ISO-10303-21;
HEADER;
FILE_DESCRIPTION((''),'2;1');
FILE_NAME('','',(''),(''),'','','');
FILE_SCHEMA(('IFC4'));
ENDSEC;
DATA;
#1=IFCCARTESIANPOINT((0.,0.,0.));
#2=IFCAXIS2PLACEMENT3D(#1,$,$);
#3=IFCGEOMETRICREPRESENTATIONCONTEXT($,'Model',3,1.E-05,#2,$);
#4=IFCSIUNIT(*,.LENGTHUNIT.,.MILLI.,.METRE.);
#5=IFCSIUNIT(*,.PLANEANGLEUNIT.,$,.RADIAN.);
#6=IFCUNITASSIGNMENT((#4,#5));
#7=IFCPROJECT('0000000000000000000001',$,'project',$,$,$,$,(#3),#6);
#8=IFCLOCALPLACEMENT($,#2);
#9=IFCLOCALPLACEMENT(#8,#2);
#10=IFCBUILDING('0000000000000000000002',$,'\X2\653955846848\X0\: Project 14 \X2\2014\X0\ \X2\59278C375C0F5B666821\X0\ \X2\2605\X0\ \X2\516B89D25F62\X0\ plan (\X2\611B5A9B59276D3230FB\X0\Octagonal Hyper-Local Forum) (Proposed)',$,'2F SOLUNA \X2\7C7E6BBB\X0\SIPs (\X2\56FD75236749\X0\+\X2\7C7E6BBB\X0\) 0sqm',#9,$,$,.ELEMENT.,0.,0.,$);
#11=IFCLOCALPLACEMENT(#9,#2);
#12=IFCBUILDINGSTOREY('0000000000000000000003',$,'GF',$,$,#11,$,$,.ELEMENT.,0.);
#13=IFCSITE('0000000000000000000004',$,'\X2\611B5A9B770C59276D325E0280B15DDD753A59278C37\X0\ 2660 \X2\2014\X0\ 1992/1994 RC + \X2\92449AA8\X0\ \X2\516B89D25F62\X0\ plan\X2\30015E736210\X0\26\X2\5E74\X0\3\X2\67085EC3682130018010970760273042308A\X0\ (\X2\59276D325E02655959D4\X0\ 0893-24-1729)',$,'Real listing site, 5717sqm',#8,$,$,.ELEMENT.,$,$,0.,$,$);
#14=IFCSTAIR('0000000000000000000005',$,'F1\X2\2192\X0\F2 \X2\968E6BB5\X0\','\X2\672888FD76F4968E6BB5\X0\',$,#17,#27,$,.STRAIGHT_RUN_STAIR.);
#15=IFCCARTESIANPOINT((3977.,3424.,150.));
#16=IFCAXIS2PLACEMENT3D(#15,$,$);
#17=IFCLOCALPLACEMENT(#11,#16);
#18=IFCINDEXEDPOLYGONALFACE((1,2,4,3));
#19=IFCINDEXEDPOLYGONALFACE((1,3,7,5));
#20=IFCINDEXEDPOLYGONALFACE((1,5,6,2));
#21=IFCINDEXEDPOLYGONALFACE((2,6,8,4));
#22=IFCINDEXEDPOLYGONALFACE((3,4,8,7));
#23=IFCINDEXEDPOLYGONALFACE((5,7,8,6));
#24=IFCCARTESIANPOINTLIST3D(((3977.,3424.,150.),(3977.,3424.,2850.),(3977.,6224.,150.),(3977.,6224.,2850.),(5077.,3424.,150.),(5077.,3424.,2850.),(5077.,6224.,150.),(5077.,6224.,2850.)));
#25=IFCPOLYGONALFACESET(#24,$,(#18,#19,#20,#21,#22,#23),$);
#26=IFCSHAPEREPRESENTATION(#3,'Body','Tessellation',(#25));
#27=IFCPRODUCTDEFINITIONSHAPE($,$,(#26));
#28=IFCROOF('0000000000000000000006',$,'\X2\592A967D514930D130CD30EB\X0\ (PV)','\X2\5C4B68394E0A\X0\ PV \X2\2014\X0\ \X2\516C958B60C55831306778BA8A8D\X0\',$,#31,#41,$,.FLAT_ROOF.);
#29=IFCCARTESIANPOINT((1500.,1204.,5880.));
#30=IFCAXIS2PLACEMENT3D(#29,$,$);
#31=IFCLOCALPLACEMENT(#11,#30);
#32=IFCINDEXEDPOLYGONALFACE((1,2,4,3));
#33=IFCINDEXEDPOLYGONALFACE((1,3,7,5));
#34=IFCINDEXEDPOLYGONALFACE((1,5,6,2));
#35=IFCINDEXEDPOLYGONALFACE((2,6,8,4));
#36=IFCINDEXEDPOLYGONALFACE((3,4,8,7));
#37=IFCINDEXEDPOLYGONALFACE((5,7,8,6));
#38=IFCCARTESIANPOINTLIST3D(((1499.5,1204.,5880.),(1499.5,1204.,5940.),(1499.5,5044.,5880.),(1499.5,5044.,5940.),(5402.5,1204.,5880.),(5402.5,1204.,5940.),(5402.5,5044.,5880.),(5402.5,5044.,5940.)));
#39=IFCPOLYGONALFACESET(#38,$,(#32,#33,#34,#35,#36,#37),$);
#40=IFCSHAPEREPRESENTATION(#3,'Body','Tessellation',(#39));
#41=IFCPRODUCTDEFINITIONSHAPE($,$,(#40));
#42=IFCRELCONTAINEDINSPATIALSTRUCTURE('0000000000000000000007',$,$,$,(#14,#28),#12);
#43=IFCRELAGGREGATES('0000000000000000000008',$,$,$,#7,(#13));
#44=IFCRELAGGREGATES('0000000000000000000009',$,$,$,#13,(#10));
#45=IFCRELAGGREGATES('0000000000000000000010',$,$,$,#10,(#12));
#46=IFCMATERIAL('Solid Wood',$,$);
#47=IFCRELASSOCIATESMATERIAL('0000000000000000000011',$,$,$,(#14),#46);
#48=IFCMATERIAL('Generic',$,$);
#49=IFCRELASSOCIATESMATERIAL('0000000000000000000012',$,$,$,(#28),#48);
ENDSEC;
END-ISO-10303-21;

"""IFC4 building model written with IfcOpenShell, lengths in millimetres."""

from ifc_helpers import new_model, si_unit, frame, frame_2d, origin, place, context, project, spatial, rectangle, extrude, material, element, save


model = new_model("IFC4")

# Units and contexts
model_context = context("Model", 3, precision=1e-05, world=origin())
ifc_project = project(units=[si_unit("LENGTHUNIT", "METRE", prefix="MILLI"), si_unit("PLANEANGLEUNIT", "RADIAN")], contexts=[model_context])

# Site, building, storey
site_placement = place(None, origin())
site = spatial("IfcSite", under=ifc_project, at=site_placement, Name="愛媛県大洲市肱川町大谷 2660 — 1992/1994 RC + 鉄骨 八角形 plan、平成26年3月廃校、耐震性あり (大洲市教委 0893-24-1729)", ObjectType="Real listing site, 5717sqm", CompositionType="ELEMENT", RefElevation=0.0)
building_placement = place(site_placement, origin())
building = spatial("IfcBuilding", under=site, at=building_placement, Name="改善案: Project 14 — 大谷小学校 ★ 八角形 plan (愛媛大洲・Octagonal Hyper-Local Forum) (Proposed)", ObjectType="2F SOLUNA 籾殻SIPs (国産杉+籾殻) 0sqm", CompositionType="ELEMENT", ElevationOfRefHeight=0.0, ElevationOfTerrain=0.0)
storey_placement = place(building_placement, origin())
storey = spatial("IfcBuildingStorey", under=building, at=storey_placement, Name="GF", CompositionType="ELEMENT", Elevation=0.0)

# Shared definitions
ifc_material_1 = material(Name="Generic")

# Stair
ifc_material_2 = material(Name="Solid Wood")
stair_placement = place(storey_placement, frame((3977.0, 3424.0, 150.0)))
element("IfcStair", 1, at=stair_placement, inside=storey, material=ifc_material_2, Name="F1→F2 階段", Description="木製直階段", PredefinedType="STRAIGHT_RUN_STAIR", context=model_context, shape_type="SweptSolid", body=[
    extrude(rectangle(XDim=1100.0, YDim=2800.0, at=frame_2d((550.0, 1400.0))), frame((3977.0, 3424.0, 150.0)), (0.0, 0.0, 1.0), 2700.0),
])

# Roof
roof_placement = place(storey_placement, frame((1500.0, 1204.0, 5880.0)))
element("IfcRoof", 2, at=roof_placement, inside=storey, material=ifc_material_1, Name="太陽光パネル (PV)", Description="屋根上 PV — 公開情報で確認", PredefinedType="FLAT_ROOF", context=model_context, shape_type="SweptSolid", body=[
    extrude(rectangle(XDim=3903.0, YDim=3840.0, at=frame_2d((1951.0, 1920.0))), frame((1500.0, 1204.0, 5880.0)), (0.0, 0.0, 1.0), 60.0),
])

save(model, "model.ifc")
